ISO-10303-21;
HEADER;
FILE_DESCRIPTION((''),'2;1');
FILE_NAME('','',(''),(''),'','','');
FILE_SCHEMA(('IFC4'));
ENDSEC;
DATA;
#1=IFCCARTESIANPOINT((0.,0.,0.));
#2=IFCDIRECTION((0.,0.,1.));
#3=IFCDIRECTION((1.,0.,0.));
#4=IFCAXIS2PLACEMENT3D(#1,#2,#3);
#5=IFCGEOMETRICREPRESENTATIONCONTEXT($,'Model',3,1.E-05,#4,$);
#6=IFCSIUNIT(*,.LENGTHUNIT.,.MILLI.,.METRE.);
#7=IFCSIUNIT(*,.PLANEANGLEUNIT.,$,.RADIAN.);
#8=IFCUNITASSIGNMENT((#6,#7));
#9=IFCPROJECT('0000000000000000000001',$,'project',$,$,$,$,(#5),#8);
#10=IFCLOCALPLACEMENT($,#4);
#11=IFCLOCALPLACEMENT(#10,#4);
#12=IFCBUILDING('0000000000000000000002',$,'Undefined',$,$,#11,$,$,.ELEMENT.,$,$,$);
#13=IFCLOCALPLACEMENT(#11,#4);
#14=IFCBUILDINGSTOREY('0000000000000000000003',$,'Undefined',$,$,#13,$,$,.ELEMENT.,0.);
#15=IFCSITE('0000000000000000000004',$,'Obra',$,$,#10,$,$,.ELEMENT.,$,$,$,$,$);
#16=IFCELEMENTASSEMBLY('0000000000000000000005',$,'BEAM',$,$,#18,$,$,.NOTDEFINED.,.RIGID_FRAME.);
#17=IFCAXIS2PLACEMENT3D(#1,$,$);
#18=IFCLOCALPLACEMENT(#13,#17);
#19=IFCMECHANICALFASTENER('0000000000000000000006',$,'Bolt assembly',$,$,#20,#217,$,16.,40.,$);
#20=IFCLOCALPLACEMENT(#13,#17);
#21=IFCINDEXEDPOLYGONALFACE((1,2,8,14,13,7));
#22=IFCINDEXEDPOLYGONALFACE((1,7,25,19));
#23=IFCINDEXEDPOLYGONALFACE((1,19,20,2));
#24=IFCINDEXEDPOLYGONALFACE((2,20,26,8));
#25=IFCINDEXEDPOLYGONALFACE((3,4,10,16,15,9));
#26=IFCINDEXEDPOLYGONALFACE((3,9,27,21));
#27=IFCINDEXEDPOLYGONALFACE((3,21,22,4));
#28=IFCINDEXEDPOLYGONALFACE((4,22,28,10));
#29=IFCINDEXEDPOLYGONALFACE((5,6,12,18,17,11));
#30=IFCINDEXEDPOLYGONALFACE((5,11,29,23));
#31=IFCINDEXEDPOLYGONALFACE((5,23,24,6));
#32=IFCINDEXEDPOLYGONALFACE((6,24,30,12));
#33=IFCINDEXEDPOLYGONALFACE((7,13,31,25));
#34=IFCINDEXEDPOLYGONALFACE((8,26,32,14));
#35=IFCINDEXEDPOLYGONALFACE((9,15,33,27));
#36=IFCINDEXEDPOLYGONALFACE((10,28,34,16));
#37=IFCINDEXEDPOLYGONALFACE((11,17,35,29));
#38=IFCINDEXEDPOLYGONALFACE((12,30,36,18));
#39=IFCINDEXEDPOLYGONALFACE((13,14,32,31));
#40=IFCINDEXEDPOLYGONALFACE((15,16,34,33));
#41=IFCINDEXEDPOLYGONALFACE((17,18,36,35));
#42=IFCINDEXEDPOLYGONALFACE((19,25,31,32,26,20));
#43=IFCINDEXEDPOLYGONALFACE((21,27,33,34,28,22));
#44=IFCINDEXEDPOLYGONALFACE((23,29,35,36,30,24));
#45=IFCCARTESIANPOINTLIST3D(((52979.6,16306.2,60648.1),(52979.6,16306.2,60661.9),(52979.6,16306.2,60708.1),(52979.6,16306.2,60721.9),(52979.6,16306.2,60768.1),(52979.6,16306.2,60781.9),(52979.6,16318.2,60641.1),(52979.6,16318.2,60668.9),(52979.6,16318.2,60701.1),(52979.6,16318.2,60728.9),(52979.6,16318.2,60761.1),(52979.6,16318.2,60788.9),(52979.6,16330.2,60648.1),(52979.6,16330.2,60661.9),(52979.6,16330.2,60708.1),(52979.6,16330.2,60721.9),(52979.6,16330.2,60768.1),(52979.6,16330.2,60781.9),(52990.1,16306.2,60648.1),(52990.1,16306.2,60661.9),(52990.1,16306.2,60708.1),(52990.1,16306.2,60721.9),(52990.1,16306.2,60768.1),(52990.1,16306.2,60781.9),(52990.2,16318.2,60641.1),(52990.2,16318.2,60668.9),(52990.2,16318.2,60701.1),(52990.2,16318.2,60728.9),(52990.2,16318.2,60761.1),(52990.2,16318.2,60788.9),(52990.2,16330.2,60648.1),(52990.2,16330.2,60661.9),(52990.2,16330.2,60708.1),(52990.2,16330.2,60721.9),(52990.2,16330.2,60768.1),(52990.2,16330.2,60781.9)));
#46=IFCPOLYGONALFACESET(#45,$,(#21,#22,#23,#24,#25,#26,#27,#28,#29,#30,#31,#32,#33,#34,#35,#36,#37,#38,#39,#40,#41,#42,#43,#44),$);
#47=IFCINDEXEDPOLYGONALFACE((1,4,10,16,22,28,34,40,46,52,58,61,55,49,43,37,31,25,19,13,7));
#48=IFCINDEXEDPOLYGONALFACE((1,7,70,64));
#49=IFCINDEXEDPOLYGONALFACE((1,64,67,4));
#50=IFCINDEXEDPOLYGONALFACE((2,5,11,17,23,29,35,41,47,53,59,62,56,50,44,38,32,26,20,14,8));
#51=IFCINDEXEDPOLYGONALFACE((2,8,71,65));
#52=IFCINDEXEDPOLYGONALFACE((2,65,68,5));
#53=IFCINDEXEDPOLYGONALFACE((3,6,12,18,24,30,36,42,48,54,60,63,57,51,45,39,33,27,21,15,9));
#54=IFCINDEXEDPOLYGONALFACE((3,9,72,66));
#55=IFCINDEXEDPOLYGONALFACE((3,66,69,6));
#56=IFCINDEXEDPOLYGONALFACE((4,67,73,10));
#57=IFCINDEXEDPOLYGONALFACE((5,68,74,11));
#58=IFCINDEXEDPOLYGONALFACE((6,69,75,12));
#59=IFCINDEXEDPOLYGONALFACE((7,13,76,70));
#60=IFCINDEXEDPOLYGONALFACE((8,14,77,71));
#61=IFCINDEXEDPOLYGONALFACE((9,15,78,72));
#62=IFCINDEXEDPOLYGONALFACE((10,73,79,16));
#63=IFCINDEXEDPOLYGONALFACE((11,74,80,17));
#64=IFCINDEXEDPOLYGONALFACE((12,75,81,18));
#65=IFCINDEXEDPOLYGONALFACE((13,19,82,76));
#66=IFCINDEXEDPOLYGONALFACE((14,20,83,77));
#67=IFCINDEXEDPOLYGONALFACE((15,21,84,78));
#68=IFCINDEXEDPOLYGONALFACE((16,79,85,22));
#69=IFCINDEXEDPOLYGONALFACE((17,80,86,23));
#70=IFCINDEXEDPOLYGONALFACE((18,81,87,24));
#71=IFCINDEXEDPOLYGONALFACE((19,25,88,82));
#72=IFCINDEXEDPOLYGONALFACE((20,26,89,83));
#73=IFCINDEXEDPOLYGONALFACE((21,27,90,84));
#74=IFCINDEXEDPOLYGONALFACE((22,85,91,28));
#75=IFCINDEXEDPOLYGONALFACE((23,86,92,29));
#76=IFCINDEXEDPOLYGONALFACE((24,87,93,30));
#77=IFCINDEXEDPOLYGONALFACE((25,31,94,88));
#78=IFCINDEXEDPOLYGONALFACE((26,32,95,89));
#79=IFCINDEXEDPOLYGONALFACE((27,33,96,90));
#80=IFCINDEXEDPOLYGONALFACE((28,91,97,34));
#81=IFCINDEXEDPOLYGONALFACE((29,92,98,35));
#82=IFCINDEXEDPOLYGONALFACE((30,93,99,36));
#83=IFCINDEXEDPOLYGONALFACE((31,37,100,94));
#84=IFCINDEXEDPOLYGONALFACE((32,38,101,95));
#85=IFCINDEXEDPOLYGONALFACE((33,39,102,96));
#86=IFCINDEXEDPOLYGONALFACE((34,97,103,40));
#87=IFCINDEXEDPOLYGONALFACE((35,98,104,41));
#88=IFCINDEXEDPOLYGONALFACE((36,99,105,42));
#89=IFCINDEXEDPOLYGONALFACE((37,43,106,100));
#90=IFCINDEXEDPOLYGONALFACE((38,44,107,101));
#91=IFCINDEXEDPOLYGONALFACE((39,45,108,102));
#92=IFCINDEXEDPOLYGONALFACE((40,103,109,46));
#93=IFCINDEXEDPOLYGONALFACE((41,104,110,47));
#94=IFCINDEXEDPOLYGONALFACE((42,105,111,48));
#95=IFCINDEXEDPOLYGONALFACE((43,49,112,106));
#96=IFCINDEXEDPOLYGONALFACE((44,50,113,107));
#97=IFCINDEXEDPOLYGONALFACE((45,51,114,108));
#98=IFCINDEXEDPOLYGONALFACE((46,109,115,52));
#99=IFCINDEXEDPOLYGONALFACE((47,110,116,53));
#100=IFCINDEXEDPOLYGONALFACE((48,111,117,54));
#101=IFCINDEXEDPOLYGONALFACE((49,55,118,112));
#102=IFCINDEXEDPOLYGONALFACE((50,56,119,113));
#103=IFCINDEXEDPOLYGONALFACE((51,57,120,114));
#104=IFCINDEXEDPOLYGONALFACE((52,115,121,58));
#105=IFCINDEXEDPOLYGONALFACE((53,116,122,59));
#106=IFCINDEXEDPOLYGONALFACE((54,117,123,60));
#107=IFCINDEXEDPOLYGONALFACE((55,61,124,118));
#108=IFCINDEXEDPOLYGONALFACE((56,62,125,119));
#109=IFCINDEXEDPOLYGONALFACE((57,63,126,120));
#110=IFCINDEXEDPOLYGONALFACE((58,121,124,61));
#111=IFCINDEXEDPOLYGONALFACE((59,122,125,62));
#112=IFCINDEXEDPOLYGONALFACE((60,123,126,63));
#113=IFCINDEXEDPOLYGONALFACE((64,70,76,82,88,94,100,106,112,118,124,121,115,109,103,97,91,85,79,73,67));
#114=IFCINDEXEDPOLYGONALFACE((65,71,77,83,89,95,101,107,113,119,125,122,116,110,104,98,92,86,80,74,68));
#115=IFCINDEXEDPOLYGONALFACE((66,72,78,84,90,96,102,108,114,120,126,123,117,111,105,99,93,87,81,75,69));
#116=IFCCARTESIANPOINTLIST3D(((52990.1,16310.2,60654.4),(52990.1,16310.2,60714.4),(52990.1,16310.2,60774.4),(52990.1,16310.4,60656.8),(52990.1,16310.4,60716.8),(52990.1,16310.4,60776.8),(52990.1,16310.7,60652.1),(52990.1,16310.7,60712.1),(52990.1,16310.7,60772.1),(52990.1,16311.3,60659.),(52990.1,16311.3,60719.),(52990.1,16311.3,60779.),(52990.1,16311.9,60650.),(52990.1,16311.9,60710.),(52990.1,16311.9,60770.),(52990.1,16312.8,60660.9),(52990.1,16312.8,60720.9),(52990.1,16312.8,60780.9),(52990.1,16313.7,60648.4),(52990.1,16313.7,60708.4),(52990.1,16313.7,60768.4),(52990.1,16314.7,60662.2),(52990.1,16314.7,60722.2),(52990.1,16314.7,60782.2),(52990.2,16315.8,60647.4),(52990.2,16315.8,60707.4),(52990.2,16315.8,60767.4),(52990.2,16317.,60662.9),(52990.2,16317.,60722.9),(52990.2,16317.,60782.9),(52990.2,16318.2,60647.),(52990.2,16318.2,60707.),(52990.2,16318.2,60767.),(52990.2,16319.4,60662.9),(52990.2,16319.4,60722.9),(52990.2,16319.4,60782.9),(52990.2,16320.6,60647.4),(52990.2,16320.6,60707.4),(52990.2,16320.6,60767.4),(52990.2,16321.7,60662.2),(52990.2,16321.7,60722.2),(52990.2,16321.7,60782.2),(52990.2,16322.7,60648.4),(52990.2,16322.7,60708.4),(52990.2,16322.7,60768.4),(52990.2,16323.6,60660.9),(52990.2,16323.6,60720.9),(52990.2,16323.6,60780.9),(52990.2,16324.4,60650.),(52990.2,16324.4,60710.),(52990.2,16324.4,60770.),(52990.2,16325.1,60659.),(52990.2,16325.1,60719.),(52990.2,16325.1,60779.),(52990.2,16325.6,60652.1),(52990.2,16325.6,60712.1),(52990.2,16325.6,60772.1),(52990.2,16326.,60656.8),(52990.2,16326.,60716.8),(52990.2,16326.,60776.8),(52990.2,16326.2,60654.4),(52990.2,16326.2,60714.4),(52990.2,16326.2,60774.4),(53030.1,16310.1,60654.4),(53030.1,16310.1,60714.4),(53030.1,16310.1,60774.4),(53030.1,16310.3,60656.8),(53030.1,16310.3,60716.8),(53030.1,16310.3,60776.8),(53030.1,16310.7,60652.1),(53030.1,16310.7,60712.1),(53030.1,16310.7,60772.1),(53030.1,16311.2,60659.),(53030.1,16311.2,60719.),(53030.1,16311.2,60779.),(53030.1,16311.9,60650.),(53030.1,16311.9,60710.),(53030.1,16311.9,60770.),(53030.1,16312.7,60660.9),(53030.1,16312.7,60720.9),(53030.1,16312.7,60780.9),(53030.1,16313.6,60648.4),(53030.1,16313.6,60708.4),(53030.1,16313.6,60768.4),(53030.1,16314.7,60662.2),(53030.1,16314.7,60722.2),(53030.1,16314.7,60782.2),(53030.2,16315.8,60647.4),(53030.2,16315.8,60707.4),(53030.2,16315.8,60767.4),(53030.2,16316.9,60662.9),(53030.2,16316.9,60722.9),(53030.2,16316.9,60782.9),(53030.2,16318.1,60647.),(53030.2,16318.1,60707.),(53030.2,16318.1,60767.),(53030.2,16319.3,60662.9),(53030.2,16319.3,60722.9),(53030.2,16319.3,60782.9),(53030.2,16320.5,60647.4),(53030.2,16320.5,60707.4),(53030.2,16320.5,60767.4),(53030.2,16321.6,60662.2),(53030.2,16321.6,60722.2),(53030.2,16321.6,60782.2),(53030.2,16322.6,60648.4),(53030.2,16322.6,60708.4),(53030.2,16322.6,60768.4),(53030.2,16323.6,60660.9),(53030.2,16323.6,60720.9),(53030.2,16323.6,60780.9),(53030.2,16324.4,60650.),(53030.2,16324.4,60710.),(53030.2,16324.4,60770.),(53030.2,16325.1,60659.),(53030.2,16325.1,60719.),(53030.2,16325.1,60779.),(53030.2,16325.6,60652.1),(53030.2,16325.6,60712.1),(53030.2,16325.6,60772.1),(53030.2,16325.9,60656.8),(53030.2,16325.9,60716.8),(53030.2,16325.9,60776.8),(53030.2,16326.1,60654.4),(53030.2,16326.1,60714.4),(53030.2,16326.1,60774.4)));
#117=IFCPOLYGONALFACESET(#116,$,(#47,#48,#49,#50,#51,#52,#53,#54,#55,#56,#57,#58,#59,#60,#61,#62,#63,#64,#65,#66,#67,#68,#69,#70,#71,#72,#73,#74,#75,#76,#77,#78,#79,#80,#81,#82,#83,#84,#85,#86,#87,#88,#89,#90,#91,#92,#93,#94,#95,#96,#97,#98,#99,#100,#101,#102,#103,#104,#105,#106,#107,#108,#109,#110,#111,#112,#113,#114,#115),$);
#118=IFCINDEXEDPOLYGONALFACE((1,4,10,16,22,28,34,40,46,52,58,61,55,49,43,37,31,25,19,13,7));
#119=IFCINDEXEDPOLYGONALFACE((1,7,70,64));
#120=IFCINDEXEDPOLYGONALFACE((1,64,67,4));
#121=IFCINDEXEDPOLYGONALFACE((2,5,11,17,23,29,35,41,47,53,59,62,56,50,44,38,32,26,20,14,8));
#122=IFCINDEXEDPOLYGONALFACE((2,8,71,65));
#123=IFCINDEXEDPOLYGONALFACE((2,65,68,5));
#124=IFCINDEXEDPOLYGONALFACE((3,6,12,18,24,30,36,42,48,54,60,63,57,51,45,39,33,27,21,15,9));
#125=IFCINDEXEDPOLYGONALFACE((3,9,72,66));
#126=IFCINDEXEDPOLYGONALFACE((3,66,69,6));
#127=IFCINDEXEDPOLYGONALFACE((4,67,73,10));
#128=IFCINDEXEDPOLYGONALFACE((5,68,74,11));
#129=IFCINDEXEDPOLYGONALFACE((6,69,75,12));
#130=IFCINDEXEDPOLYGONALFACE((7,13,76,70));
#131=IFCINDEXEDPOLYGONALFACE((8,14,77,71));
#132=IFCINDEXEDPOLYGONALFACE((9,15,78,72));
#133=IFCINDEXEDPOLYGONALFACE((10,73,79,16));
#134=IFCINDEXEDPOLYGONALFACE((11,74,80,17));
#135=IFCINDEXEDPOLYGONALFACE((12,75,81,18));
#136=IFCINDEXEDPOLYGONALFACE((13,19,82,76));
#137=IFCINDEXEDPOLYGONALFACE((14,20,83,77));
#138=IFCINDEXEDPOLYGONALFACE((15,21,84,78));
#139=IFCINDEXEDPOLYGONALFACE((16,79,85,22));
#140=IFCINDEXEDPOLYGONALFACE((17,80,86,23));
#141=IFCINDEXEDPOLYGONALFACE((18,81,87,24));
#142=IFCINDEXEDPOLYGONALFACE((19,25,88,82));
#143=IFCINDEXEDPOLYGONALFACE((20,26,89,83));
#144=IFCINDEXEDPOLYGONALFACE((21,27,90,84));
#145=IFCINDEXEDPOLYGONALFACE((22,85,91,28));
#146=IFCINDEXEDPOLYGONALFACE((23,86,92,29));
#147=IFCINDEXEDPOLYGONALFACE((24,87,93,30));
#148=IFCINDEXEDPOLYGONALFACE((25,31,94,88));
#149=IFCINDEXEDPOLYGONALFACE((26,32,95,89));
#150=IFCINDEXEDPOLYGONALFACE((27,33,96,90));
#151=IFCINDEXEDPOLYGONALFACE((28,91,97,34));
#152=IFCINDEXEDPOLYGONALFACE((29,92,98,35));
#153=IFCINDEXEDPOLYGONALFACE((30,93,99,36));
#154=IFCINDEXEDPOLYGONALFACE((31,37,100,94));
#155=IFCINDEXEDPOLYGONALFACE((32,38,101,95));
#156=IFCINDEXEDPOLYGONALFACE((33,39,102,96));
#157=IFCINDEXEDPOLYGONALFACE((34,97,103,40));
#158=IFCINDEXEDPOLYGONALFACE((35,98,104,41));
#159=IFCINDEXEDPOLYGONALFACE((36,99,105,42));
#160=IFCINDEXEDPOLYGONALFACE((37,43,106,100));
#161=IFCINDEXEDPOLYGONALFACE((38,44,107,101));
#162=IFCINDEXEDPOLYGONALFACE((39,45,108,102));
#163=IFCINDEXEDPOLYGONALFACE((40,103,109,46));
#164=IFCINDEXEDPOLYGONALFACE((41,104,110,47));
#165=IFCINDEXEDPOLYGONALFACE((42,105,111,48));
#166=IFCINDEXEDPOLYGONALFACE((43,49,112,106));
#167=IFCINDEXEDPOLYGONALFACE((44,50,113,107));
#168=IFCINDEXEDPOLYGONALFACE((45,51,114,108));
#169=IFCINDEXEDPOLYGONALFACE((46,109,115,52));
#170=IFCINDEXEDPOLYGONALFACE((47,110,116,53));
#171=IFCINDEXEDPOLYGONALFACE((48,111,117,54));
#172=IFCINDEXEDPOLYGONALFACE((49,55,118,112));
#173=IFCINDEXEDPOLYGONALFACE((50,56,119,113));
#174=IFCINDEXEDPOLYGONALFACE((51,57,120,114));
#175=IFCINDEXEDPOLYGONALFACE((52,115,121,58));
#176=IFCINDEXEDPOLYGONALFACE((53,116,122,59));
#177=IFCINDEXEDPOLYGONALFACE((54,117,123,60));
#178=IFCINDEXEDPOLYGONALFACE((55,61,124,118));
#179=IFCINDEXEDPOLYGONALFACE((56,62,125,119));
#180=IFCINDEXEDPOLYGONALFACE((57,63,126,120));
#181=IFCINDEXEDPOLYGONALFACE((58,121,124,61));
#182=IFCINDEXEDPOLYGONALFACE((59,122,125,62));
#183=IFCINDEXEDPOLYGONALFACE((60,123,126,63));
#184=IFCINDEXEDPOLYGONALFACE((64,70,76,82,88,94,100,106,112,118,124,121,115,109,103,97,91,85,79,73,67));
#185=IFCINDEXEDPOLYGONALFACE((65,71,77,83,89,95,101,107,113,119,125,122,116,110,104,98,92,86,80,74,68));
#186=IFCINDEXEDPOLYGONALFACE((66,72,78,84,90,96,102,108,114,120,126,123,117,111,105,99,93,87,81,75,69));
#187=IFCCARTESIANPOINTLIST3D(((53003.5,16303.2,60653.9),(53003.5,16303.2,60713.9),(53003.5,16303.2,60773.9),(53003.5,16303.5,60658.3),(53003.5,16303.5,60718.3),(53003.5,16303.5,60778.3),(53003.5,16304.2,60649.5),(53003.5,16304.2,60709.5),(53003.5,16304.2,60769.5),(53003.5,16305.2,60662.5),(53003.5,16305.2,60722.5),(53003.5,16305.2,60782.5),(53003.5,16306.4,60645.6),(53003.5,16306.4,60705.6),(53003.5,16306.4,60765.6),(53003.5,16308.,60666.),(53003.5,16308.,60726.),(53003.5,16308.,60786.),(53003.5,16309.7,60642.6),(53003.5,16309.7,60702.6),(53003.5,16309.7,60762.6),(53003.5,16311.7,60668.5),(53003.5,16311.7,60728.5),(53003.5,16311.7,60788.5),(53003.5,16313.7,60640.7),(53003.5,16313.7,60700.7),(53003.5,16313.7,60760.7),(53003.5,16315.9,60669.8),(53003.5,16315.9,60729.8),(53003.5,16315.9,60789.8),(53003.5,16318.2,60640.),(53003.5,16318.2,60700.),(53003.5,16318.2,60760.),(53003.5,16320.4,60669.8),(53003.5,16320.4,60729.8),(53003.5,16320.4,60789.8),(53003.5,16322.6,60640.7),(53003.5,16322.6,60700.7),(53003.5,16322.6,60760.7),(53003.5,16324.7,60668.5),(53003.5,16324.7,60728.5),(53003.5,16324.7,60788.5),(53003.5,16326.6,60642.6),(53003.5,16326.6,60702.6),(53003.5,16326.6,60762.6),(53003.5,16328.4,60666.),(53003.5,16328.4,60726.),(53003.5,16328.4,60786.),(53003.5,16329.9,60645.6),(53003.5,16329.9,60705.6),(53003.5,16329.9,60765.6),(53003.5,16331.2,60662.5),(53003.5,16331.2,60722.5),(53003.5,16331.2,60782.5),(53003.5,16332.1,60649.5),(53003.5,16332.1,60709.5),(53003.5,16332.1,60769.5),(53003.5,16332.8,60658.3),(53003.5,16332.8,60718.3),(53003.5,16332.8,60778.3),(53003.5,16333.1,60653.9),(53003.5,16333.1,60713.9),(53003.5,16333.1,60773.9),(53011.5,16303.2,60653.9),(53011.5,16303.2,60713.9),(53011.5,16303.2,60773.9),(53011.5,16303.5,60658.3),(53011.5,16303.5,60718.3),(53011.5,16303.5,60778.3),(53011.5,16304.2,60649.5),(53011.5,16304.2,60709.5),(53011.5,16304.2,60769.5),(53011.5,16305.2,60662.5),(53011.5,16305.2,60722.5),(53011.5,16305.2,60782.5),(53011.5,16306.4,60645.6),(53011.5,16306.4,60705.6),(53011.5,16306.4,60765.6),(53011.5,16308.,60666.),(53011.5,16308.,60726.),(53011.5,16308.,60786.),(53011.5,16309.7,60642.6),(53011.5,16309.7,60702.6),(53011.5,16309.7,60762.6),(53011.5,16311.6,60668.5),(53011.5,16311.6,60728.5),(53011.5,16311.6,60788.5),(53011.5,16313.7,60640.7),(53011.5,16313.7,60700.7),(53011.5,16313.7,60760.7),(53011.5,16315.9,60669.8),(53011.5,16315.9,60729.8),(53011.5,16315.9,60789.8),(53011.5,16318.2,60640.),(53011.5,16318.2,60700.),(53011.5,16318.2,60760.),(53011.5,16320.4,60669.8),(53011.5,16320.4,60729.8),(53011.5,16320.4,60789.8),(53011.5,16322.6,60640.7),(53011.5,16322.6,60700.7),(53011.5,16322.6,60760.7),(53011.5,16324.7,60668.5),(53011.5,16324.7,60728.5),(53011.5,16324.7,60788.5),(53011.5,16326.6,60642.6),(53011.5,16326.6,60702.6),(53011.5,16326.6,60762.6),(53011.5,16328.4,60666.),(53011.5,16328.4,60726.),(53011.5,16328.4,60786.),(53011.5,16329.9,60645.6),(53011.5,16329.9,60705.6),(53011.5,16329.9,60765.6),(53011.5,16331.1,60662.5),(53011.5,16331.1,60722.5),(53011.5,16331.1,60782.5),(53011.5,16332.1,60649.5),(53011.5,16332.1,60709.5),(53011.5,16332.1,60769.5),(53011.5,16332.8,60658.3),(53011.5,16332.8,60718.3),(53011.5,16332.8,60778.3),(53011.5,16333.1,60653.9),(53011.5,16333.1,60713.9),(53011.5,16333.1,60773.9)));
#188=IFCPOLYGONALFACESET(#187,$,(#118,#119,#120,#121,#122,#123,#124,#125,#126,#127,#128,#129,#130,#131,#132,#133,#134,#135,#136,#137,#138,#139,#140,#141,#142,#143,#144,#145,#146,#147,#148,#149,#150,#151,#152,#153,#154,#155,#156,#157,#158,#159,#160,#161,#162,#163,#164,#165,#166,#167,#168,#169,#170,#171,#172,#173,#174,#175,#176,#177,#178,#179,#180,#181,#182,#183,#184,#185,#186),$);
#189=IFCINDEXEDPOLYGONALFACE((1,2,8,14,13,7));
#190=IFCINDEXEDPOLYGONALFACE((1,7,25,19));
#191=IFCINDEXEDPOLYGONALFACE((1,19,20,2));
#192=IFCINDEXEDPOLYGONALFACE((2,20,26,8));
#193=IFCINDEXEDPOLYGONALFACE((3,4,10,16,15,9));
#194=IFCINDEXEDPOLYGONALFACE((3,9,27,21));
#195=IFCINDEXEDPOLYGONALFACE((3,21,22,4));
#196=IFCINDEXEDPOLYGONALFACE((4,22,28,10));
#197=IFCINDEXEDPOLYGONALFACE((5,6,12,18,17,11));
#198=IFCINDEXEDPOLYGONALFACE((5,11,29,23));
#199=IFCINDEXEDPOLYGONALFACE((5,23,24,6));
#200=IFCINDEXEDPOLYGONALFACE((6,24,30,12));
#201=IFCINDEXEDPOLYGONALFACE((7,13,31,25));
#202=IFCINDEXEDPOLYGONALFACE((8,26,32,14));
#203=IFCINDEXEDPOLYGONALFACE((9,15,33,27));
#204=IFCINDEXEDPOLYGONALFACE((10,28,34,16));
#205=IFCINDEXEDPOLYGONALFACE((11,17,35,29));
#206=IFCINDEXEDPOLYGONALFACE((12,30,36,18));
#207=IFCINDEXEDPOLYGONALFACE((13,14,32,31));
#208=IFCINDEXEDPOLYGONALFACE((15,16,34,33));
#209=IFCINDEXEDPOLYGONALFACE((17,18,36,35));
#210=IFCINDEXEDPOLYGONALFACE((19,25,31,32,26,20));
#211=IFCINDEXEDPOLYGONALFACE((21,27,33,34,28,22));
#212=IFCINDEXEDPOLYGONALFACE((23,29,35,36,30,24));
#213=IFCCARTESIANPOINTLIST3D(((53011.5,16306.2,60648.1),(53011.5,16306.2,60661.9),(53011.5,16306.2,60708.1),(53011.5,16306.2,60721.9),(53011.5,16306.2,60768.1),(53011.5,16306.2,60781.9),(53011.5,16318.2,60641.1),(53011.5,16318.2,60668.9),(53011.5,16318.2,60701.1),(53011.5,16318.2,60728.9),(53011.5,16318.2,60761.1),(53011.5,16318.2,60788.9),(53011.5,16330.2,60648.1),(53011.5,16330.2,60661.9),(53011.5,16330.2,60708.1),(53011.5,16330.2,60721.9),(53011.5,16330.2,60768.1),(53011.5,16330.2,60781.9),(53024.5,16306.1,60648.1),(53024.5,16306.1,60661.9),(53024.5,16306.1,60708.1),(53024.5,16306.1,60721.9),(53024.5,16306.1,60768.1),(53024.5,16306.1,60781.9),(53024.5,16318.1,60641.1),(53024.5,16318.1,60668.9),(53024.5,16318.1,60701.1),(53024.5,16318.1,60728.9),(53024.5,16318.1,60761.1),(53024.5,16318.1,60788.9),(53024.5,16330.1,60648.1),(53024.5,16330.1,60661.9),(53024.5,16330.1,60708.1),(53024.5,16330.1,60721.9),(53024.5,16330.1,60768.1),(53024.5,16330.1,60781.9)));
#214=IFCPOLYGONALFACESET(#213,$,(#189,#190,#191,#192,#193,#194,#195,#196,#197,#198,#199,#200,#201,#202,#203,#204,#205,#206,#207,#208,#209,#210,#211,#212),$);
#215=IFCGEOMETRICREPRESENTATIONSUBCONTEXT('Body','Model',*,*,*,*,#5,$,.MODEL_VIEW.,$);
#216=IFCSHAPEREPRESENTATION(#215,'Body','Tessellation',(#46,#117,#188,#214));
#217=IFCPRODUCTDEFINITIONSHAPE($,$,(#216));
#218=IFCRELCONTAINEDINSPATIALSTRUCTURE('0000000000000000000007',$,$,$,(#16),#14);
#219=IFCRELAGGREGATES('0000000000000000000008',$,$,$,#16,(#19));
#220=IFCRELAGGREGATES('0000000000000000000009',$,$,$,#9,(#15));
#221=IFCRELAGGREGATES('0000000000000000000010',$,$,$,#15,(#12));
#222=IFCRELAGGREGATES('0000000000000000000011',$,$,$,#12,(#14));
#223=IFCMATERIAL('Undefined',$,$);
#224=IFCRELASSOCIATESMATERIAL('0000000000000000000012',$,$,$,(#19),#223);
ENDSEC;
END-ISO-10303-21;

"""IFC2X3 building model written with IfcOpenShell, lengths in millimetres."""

from ifc_helpers import new_model, si_unit, frame, origin_with_axes, origin_2d_with_axis, place, context, subcontext, project, spatial, polyline, circle, outline, extrude, source, transform, mapped, material, element, aggregate, save


model = new_model("IFC2X3")

# Units and contexts
model_context = context("Model", 3, precision=1e-05, world=origin_with_axes())
body_context = subcontext(model_context, "Body", "Model", "MODEL_VIEW")
ifc_project = project(units=[si_unit("LENGTHUNIT", "METRE", prefix="MILLI"), si_unit("PLANEANGLEUNIT", "RADIAN")], contexts=[model_context])

# Site, building, storey
site_placement = place(None, origin_with_axes())
site = spatial("IfcSite", under=ifc_project, at=site_placement, Name="Obra", CompositionType="ELEMENT")
building_placement = place(site_placement, origin_with_axes())
building = spatial("IfcBuilding", under=site, at=building_placement, Name="Undefined", CompositionType="ELEMENT")
storey_placement = place(building_placement, origin_with_axes())
storey = spatial("IfcBuildingStorey", under=building, at=storey_placement, Name="Undefined", CompositionType="ELEMENT", Elevation=0.0)

# Element assembly, mechanical fastener
ifc_material_1 = material(Name="Undefined")
assembly_1_placement = place(storey_placement, origin_with_axes())
assembly_1 = element("IfcElementAssembly", 1, at=assembly_1_placement, inside=storey, Name="BEAM", AssemblyPlace="NOTDEFINED", PredefinedType="RIGID_FRAME")
shared_shape_1 = source(origin_with_axes(), body_context, "Body", "SweptSolid", [
    extrude(outline(polyline([(13.9, 0.0), (6.9, 12.0), (-6.9, 12.0), (-13.9, 0.0), (-6.9, -12.0), (6.9, -12.0), (13.9, 0.0)])), frame((0.0, -19.7, 0.0), z_axis=(0.0, 1.0, 0.0), x_axis=(1.0, 0.0, 0.0)), (0.0, 0.0, 1.0), 10.6),
    extrude(circle(Radius=8.0, at=origin_2d_with_axis()), frame((0.0, -9.1, 0.0), z_axis=(0.0, 1.0, 0.0), x_axis=(1.0, 0.0, 0.0)), (0.0, 0.0, 1.0), 40.0),
    extrude(circle(Radius=15.0, at=origin_2d_with_axis()), frame((0.0, 4.2, 0.0), z_axis=(0.0, 1.0, 0.0), x_axis=(1.0, 0.0, 0.0)), (0.0, 0.0, 1.0), 8.0),
    extrude(outline(polyline([(13.9, 0.0), (6.9, 12.0), (-6.9, 12.0), (-13.9, 0.0), (-6.9, -12.0), (6.9, -12.0), (13.9, 0.0)])), frame((0.0, 12.2, 0.0), z_axis=(0.0, 1.0, 0.0), x_axis=(1.0, 0.0, 0.0)), (0.0, 0.0, 1.0), 13.0),
])
mechanical_fastener_1_placement = place(assembly_1_placement, frame((52999.3, 16368.2, 60835.0), z_axis=(-0.001649, -0.999999, 0.0), x_axis=(0.0, 0.0, -1.0)))
mechanical_fastener_1 = element("IfcMechanicalFastener", 2, at=mechanical_fastener_1_placement, material=ifc_material_1, Name="Bolt assembly", NominalDiameter=16.0, NominalLength=40.0, context=body_context, shape_type="MappedRepresentation", body=[
    mapped(shared_shape_1, transform((60.0, 0.0, 50.0))),
    mapped(shared_shape_1, transform((120.0, 0.0, 50.0))),
    mapped(shared_shape_1, transform((180.0, 0.0, 50.0))),
])
aggregate(assembly_1, [mechanical_fastener_1])

save(model, "model.ifc")
